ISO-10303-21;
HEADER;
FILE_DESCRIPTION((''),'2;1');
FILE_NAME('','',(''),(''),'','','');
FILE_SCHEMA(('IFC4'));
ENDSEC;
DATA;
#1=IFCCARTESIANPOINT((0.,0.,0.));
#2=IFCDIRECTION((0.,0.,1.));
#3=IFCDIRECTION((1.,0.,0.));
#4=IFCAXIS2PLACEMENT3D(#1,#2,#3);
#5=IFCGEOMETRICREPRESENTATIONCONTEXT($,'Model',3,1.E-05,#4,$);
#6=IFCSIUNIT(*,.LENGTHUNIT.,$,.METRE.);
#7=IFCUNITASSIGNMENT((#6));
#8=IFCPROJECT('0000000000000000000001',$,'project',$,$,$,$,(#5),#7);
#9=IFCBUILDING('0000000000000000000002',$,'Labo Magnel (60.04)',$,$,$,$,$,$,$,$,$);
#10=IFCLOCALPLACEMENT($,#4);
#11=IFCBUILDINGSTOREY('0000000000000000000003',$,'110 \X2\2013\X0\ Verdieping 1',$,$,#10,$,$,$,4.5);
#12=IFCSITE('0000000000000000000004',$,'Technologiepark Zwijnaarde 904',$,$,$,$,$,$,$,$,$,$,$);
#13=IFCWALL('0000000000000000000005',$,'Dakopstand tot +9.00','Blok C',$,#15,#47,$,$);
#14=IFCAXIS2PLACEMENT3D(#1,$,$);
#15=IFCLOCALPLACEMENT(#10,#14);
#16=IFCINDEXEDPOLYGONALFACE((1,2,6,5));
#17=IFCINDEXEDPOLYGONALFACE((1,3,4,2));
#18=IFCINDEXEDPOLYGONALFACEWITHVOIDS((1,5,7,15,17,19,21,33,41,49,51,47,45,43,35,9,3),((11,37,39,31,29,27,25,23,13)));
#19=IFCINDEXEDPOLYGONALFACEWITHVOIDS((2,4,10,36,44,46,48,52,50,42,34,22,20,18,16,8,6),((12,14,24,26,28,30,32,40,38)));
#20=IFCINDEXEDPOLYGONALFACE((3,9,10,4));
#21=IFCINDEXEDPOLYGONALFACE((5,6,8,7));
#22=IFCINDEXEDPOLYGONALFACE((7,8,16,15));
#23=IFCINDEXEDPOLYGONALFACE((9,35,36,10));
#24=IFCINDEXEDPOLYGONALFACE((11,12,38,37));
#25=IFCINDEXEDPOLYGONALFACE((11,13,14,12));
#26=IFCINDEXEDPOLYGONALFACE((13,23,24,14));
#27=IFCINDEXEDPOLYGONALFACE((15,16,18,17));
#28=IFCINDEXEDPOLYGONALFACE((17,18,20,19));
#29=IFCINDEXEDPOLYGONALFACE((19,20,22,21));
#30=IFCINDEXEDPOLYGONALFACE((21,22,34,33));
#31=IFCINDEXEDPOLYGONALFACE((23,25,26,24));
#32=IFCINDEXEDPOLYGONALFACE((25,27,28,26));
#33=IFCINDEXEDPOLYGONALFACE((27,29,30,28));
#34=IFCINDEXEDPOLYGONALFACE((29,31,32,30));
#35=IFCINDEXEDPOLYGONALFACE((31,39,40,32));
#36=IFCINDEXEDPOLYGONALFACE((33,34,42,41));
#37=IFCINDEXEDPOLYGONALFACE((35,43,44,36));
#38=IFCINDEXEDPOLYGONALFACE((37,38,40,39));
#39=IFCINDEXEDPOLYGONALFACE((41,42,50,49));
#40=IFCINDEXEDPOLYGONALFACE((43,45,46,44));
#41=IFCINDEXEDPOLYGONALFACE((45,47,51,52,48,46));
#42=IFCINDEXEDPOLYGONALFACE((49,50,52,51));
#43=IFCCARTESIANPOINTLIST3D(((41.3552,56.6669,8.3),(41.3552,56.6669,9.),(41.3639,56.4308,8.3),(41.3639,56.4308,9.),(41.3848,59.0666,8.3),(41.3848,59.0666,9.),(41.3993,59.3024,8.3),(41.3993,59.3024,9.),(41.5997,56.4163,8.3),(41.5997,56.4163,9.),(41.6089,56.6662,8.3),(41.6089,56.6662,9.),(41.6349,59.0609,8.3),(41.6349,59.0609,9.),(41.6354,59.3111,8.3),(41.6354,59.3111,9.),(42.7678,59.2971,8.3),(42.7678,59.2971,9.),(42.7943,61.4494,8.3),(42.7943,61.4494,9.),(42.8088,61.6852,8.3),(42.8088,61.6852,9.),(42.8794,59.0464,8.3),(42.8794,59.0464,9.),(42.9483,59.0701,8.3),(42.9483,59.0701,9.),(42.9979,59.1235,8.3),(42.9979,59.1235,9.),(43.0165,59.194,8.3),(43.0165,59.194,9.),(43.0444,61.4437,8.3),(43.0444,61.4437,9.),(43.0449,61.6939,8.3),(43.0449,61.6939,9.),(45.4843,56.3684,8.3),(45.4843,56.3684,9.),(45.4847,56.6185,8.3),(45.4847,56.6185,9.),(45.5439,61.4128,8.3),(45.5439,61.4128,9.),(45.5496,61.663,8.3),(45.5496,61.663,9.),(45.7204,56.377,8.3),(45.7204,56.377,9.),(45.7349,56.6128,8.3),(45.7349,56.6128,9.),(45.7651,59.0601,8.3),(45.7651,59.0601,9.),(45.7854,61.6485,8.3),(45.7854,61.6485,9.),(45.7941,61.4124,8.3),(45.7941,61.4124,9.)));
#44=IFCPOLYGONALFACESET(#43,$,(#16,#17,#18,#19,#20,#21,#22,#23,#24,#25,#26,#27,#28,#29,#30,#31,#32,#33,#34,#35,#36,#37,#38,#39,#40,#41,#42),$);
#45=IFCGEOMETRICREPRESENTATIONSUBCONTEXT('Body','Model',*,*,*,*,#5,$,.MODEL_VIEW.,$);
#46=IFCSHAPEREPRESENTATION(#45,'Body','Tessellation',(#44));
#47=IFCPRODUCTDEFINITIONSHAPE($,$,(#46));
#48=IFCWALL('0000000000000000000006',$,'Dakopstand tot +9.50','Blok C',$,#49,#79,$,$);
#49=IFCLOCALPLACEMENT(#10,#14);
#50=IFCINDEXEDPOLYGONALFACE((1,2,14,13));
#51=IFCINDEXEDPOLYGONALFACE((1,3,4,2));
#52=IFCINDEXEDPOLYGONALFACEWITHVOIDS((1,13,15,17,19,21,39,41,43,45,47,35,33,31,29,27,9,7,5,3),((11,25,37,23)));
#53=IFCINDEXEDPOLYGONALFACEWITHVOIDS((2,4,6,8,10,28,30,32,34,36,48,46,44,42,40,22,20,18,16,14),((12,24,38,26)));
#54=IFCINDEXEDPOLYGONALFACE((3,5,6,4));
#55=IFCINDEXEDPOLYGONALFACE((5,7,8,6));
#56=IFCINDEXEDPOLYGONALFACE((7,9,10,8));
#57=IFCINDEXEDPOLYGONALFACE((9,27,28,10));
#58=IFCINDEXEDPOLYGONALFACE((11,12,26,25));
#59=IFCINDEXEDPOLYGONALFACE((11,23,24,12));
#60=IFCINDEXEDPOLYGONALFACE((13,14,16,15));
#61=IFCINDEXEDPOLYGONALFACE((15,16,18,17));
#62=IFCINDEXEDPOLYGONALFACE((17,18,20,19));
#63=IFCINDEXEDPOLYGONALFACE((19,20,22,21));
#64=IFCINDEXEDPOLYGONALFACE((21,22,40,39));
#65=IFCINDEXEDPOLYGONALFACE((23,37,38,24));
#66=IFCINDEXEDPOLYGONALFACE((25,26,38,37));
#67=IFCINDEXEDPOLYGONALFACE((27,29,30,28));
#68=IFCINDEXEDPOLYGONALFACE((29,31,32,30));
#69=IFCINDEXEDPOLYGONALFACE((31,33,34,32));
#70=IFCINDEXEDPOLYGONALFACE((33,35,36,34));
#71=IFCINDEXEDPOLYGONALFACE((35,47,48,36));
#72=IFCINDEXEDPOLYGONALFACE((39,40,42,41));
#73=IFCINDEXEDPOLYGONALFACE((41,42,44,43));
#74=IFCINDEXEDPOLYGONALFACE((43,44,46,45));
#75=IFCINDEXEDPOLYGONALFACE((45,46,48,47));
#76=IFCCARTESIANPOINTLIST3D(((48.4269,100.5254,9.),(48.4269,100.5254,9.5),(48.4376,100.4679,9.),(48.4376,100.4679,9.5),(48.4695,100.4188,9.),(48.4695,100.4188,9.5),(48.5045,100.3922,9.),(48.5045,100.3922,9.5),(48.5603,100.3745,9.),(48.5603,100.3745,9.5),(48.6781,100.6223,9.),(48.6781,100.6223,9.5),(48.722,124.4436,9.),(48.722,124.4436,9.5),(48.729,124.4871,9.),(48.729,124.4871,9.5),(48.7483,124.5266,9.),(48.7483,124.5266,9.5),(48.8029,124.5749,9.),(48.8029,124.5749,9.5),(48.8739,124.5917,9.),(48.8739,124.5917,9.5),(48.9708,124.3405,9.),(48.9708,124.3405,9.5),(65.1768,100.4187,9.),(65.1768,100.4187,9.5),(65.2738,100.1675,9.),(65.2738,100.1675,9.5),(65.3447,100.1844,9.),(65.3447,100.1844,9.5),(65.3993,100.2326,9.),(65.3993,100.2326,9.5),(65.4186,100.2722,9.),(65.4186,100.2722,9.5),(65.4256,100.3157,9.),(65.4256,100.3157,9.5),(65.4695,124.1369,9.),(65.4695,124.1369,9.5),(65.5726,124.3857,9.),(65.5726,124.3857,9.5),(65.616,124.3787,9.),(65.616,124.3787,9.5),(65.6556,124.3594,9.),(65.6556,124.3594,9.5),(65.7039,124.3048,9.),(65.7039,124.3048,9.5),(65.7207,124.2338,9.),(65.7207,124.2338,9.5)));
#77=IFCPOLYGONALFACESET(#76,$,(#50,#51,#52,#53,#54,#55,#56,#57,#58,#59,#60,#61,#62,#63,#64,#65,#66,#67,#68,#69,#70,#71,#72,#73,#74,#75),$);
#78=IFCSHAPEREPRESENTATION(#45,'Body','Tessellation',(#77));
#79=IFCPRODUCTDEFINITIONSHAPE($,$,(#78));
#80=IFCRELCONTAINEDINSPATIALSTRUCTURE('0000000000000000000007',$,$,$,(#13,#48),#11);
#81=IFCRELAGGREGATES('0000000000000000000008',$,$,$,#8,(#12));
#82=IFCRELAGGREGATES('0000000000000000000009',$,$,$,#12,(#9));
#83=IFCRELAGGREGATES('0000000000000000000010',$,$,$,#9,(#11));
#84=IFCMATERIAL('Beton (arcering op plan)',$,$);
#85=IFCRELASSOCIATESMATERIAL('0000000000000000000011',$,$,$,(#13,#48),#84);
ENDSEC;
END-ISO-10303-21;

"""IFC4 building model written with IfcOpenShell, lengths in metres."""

from ifc_helpers import new_model, si_unit, frame, origin, origin_with_axes, place, context, subcontext, project, spatial, polyline, outline, extrude, material, element, save


model = new_model("IFC4")

# Units and contexts
model_context = context("Model", 3, precision=1e-05, world=origin_with_axes())
body_context = subcontext(model_context, "Body", "Model", "MODEL_VIEW")
ifc_project = project(units=[si_unit("LENGTHUNIT", "METRE")], contexts=[model_context])

# Site, building, storey
site = spatial("IfcSite", under=ifc_project, Name="Technologiepark Zwijnaarde 904")
building = spatial("IfcBuilding", under=site, Name="Labo Magnel (60.04)")
storey_placement = place(None, origin_with_axes())
storey = spatial("IfcBuildingStorey", under=building, at=storey_placement, Name="110 – Verdieping 1", Elevation=4.5)

# Shared definitions
ifc_material_1 = material(Name="Beton (arcering op plan)")

# Walls
wall_1_placement = place(storey_placement, frame((0.0, 0.0, 8.3), z_axis=(0.0, 0.0, 1.0), x_axis=(1.0, 0.0, 0.0)))
element("IfcWall", 1, at=wall_1_placement, inside=storey, material=ifc_material_1, Name="Dakopstand tot +9.00", Description="Blok C", context=body_context, shape_type="SweptSolid", body=[
    extrude(outline(polyline([(41.3552, 56.6669), (41.3848, 59.0666), (41.3993, 59.3024), (41.6354, 59.3111), (42.7678, 59.2971), (42.7943, 61.4494), (42.8088, 61.6852), (43.0449, 61.6939), (45.5496, 61.663), (45.7854, 61.6485), (45.7941, 61.4124), (45.7651, 59.0601), (45.7349, 56.6128), (45.7204, 56.377), (45.4843, 56.3684), (41.5997, 56.4163), (41.3639, 56.4308), (41.3552, 56.6669)]), holes=[polyline([(41.6089, 56.6662), (45.4847, 56.6185), (45.5439, 61.4128), (43.0444, 61.4437), (43.0165, 59.194), (42.9979, 59.1235), (42.9483, 59.0701), (42.8794, 59.0464), (41.6349, 59.0609), (41.6089, 56.6662)])]), origin(), (0.0, 0.0, 1.0), 0.7),
])
wall_2_placement = place(storey_placement, frame((0.0, 0.0, 9.0), z_axis=(0.0, 0.0, 1.0), x_axis=(1.0, 0.0, 0.0)))
element("IfcWall", 2, at=wall_2_placement, inside=storey, material=ifc_material_1, Name="Dakopstand tot +9.50", Description="Blok C", context=body_context, shape_type="SweptSolid", body=[
    extrude(outline(polyline([(48.5603, 100.3745), (48.5045, 100.3922), (48.4695, 100.4188), (48.4376, 100.4679), (48.4269, 100.5254), (48.722, 124.4436), (48.729, 124.4871), (48.7483, 124.5266), (48.8029, 124.5749), (48.8739, 124.5917), (65.5726, 124.3857), (65.616, 124.3787), (65.6556, 124.3594), (65.7039, 124.3048), (65.7207, 124.2338), (65.4256, 100.3157), (65.4186, 100.2722), (65.3993, 100.2326), (65.3447, 100.1844), (65.2738, 100.1675), (48.5603, 100.3745)]), holes=[polyline([(48.6781, 100.6223), (65.1768, 100.4187), (65.4695, 124.1369), (48.9708, 124.3405), (48.6781, 100.6223)])]), origin(), (0.0, 0.0, 1.0), 0.5),
])

save(model, "model.ifc")
